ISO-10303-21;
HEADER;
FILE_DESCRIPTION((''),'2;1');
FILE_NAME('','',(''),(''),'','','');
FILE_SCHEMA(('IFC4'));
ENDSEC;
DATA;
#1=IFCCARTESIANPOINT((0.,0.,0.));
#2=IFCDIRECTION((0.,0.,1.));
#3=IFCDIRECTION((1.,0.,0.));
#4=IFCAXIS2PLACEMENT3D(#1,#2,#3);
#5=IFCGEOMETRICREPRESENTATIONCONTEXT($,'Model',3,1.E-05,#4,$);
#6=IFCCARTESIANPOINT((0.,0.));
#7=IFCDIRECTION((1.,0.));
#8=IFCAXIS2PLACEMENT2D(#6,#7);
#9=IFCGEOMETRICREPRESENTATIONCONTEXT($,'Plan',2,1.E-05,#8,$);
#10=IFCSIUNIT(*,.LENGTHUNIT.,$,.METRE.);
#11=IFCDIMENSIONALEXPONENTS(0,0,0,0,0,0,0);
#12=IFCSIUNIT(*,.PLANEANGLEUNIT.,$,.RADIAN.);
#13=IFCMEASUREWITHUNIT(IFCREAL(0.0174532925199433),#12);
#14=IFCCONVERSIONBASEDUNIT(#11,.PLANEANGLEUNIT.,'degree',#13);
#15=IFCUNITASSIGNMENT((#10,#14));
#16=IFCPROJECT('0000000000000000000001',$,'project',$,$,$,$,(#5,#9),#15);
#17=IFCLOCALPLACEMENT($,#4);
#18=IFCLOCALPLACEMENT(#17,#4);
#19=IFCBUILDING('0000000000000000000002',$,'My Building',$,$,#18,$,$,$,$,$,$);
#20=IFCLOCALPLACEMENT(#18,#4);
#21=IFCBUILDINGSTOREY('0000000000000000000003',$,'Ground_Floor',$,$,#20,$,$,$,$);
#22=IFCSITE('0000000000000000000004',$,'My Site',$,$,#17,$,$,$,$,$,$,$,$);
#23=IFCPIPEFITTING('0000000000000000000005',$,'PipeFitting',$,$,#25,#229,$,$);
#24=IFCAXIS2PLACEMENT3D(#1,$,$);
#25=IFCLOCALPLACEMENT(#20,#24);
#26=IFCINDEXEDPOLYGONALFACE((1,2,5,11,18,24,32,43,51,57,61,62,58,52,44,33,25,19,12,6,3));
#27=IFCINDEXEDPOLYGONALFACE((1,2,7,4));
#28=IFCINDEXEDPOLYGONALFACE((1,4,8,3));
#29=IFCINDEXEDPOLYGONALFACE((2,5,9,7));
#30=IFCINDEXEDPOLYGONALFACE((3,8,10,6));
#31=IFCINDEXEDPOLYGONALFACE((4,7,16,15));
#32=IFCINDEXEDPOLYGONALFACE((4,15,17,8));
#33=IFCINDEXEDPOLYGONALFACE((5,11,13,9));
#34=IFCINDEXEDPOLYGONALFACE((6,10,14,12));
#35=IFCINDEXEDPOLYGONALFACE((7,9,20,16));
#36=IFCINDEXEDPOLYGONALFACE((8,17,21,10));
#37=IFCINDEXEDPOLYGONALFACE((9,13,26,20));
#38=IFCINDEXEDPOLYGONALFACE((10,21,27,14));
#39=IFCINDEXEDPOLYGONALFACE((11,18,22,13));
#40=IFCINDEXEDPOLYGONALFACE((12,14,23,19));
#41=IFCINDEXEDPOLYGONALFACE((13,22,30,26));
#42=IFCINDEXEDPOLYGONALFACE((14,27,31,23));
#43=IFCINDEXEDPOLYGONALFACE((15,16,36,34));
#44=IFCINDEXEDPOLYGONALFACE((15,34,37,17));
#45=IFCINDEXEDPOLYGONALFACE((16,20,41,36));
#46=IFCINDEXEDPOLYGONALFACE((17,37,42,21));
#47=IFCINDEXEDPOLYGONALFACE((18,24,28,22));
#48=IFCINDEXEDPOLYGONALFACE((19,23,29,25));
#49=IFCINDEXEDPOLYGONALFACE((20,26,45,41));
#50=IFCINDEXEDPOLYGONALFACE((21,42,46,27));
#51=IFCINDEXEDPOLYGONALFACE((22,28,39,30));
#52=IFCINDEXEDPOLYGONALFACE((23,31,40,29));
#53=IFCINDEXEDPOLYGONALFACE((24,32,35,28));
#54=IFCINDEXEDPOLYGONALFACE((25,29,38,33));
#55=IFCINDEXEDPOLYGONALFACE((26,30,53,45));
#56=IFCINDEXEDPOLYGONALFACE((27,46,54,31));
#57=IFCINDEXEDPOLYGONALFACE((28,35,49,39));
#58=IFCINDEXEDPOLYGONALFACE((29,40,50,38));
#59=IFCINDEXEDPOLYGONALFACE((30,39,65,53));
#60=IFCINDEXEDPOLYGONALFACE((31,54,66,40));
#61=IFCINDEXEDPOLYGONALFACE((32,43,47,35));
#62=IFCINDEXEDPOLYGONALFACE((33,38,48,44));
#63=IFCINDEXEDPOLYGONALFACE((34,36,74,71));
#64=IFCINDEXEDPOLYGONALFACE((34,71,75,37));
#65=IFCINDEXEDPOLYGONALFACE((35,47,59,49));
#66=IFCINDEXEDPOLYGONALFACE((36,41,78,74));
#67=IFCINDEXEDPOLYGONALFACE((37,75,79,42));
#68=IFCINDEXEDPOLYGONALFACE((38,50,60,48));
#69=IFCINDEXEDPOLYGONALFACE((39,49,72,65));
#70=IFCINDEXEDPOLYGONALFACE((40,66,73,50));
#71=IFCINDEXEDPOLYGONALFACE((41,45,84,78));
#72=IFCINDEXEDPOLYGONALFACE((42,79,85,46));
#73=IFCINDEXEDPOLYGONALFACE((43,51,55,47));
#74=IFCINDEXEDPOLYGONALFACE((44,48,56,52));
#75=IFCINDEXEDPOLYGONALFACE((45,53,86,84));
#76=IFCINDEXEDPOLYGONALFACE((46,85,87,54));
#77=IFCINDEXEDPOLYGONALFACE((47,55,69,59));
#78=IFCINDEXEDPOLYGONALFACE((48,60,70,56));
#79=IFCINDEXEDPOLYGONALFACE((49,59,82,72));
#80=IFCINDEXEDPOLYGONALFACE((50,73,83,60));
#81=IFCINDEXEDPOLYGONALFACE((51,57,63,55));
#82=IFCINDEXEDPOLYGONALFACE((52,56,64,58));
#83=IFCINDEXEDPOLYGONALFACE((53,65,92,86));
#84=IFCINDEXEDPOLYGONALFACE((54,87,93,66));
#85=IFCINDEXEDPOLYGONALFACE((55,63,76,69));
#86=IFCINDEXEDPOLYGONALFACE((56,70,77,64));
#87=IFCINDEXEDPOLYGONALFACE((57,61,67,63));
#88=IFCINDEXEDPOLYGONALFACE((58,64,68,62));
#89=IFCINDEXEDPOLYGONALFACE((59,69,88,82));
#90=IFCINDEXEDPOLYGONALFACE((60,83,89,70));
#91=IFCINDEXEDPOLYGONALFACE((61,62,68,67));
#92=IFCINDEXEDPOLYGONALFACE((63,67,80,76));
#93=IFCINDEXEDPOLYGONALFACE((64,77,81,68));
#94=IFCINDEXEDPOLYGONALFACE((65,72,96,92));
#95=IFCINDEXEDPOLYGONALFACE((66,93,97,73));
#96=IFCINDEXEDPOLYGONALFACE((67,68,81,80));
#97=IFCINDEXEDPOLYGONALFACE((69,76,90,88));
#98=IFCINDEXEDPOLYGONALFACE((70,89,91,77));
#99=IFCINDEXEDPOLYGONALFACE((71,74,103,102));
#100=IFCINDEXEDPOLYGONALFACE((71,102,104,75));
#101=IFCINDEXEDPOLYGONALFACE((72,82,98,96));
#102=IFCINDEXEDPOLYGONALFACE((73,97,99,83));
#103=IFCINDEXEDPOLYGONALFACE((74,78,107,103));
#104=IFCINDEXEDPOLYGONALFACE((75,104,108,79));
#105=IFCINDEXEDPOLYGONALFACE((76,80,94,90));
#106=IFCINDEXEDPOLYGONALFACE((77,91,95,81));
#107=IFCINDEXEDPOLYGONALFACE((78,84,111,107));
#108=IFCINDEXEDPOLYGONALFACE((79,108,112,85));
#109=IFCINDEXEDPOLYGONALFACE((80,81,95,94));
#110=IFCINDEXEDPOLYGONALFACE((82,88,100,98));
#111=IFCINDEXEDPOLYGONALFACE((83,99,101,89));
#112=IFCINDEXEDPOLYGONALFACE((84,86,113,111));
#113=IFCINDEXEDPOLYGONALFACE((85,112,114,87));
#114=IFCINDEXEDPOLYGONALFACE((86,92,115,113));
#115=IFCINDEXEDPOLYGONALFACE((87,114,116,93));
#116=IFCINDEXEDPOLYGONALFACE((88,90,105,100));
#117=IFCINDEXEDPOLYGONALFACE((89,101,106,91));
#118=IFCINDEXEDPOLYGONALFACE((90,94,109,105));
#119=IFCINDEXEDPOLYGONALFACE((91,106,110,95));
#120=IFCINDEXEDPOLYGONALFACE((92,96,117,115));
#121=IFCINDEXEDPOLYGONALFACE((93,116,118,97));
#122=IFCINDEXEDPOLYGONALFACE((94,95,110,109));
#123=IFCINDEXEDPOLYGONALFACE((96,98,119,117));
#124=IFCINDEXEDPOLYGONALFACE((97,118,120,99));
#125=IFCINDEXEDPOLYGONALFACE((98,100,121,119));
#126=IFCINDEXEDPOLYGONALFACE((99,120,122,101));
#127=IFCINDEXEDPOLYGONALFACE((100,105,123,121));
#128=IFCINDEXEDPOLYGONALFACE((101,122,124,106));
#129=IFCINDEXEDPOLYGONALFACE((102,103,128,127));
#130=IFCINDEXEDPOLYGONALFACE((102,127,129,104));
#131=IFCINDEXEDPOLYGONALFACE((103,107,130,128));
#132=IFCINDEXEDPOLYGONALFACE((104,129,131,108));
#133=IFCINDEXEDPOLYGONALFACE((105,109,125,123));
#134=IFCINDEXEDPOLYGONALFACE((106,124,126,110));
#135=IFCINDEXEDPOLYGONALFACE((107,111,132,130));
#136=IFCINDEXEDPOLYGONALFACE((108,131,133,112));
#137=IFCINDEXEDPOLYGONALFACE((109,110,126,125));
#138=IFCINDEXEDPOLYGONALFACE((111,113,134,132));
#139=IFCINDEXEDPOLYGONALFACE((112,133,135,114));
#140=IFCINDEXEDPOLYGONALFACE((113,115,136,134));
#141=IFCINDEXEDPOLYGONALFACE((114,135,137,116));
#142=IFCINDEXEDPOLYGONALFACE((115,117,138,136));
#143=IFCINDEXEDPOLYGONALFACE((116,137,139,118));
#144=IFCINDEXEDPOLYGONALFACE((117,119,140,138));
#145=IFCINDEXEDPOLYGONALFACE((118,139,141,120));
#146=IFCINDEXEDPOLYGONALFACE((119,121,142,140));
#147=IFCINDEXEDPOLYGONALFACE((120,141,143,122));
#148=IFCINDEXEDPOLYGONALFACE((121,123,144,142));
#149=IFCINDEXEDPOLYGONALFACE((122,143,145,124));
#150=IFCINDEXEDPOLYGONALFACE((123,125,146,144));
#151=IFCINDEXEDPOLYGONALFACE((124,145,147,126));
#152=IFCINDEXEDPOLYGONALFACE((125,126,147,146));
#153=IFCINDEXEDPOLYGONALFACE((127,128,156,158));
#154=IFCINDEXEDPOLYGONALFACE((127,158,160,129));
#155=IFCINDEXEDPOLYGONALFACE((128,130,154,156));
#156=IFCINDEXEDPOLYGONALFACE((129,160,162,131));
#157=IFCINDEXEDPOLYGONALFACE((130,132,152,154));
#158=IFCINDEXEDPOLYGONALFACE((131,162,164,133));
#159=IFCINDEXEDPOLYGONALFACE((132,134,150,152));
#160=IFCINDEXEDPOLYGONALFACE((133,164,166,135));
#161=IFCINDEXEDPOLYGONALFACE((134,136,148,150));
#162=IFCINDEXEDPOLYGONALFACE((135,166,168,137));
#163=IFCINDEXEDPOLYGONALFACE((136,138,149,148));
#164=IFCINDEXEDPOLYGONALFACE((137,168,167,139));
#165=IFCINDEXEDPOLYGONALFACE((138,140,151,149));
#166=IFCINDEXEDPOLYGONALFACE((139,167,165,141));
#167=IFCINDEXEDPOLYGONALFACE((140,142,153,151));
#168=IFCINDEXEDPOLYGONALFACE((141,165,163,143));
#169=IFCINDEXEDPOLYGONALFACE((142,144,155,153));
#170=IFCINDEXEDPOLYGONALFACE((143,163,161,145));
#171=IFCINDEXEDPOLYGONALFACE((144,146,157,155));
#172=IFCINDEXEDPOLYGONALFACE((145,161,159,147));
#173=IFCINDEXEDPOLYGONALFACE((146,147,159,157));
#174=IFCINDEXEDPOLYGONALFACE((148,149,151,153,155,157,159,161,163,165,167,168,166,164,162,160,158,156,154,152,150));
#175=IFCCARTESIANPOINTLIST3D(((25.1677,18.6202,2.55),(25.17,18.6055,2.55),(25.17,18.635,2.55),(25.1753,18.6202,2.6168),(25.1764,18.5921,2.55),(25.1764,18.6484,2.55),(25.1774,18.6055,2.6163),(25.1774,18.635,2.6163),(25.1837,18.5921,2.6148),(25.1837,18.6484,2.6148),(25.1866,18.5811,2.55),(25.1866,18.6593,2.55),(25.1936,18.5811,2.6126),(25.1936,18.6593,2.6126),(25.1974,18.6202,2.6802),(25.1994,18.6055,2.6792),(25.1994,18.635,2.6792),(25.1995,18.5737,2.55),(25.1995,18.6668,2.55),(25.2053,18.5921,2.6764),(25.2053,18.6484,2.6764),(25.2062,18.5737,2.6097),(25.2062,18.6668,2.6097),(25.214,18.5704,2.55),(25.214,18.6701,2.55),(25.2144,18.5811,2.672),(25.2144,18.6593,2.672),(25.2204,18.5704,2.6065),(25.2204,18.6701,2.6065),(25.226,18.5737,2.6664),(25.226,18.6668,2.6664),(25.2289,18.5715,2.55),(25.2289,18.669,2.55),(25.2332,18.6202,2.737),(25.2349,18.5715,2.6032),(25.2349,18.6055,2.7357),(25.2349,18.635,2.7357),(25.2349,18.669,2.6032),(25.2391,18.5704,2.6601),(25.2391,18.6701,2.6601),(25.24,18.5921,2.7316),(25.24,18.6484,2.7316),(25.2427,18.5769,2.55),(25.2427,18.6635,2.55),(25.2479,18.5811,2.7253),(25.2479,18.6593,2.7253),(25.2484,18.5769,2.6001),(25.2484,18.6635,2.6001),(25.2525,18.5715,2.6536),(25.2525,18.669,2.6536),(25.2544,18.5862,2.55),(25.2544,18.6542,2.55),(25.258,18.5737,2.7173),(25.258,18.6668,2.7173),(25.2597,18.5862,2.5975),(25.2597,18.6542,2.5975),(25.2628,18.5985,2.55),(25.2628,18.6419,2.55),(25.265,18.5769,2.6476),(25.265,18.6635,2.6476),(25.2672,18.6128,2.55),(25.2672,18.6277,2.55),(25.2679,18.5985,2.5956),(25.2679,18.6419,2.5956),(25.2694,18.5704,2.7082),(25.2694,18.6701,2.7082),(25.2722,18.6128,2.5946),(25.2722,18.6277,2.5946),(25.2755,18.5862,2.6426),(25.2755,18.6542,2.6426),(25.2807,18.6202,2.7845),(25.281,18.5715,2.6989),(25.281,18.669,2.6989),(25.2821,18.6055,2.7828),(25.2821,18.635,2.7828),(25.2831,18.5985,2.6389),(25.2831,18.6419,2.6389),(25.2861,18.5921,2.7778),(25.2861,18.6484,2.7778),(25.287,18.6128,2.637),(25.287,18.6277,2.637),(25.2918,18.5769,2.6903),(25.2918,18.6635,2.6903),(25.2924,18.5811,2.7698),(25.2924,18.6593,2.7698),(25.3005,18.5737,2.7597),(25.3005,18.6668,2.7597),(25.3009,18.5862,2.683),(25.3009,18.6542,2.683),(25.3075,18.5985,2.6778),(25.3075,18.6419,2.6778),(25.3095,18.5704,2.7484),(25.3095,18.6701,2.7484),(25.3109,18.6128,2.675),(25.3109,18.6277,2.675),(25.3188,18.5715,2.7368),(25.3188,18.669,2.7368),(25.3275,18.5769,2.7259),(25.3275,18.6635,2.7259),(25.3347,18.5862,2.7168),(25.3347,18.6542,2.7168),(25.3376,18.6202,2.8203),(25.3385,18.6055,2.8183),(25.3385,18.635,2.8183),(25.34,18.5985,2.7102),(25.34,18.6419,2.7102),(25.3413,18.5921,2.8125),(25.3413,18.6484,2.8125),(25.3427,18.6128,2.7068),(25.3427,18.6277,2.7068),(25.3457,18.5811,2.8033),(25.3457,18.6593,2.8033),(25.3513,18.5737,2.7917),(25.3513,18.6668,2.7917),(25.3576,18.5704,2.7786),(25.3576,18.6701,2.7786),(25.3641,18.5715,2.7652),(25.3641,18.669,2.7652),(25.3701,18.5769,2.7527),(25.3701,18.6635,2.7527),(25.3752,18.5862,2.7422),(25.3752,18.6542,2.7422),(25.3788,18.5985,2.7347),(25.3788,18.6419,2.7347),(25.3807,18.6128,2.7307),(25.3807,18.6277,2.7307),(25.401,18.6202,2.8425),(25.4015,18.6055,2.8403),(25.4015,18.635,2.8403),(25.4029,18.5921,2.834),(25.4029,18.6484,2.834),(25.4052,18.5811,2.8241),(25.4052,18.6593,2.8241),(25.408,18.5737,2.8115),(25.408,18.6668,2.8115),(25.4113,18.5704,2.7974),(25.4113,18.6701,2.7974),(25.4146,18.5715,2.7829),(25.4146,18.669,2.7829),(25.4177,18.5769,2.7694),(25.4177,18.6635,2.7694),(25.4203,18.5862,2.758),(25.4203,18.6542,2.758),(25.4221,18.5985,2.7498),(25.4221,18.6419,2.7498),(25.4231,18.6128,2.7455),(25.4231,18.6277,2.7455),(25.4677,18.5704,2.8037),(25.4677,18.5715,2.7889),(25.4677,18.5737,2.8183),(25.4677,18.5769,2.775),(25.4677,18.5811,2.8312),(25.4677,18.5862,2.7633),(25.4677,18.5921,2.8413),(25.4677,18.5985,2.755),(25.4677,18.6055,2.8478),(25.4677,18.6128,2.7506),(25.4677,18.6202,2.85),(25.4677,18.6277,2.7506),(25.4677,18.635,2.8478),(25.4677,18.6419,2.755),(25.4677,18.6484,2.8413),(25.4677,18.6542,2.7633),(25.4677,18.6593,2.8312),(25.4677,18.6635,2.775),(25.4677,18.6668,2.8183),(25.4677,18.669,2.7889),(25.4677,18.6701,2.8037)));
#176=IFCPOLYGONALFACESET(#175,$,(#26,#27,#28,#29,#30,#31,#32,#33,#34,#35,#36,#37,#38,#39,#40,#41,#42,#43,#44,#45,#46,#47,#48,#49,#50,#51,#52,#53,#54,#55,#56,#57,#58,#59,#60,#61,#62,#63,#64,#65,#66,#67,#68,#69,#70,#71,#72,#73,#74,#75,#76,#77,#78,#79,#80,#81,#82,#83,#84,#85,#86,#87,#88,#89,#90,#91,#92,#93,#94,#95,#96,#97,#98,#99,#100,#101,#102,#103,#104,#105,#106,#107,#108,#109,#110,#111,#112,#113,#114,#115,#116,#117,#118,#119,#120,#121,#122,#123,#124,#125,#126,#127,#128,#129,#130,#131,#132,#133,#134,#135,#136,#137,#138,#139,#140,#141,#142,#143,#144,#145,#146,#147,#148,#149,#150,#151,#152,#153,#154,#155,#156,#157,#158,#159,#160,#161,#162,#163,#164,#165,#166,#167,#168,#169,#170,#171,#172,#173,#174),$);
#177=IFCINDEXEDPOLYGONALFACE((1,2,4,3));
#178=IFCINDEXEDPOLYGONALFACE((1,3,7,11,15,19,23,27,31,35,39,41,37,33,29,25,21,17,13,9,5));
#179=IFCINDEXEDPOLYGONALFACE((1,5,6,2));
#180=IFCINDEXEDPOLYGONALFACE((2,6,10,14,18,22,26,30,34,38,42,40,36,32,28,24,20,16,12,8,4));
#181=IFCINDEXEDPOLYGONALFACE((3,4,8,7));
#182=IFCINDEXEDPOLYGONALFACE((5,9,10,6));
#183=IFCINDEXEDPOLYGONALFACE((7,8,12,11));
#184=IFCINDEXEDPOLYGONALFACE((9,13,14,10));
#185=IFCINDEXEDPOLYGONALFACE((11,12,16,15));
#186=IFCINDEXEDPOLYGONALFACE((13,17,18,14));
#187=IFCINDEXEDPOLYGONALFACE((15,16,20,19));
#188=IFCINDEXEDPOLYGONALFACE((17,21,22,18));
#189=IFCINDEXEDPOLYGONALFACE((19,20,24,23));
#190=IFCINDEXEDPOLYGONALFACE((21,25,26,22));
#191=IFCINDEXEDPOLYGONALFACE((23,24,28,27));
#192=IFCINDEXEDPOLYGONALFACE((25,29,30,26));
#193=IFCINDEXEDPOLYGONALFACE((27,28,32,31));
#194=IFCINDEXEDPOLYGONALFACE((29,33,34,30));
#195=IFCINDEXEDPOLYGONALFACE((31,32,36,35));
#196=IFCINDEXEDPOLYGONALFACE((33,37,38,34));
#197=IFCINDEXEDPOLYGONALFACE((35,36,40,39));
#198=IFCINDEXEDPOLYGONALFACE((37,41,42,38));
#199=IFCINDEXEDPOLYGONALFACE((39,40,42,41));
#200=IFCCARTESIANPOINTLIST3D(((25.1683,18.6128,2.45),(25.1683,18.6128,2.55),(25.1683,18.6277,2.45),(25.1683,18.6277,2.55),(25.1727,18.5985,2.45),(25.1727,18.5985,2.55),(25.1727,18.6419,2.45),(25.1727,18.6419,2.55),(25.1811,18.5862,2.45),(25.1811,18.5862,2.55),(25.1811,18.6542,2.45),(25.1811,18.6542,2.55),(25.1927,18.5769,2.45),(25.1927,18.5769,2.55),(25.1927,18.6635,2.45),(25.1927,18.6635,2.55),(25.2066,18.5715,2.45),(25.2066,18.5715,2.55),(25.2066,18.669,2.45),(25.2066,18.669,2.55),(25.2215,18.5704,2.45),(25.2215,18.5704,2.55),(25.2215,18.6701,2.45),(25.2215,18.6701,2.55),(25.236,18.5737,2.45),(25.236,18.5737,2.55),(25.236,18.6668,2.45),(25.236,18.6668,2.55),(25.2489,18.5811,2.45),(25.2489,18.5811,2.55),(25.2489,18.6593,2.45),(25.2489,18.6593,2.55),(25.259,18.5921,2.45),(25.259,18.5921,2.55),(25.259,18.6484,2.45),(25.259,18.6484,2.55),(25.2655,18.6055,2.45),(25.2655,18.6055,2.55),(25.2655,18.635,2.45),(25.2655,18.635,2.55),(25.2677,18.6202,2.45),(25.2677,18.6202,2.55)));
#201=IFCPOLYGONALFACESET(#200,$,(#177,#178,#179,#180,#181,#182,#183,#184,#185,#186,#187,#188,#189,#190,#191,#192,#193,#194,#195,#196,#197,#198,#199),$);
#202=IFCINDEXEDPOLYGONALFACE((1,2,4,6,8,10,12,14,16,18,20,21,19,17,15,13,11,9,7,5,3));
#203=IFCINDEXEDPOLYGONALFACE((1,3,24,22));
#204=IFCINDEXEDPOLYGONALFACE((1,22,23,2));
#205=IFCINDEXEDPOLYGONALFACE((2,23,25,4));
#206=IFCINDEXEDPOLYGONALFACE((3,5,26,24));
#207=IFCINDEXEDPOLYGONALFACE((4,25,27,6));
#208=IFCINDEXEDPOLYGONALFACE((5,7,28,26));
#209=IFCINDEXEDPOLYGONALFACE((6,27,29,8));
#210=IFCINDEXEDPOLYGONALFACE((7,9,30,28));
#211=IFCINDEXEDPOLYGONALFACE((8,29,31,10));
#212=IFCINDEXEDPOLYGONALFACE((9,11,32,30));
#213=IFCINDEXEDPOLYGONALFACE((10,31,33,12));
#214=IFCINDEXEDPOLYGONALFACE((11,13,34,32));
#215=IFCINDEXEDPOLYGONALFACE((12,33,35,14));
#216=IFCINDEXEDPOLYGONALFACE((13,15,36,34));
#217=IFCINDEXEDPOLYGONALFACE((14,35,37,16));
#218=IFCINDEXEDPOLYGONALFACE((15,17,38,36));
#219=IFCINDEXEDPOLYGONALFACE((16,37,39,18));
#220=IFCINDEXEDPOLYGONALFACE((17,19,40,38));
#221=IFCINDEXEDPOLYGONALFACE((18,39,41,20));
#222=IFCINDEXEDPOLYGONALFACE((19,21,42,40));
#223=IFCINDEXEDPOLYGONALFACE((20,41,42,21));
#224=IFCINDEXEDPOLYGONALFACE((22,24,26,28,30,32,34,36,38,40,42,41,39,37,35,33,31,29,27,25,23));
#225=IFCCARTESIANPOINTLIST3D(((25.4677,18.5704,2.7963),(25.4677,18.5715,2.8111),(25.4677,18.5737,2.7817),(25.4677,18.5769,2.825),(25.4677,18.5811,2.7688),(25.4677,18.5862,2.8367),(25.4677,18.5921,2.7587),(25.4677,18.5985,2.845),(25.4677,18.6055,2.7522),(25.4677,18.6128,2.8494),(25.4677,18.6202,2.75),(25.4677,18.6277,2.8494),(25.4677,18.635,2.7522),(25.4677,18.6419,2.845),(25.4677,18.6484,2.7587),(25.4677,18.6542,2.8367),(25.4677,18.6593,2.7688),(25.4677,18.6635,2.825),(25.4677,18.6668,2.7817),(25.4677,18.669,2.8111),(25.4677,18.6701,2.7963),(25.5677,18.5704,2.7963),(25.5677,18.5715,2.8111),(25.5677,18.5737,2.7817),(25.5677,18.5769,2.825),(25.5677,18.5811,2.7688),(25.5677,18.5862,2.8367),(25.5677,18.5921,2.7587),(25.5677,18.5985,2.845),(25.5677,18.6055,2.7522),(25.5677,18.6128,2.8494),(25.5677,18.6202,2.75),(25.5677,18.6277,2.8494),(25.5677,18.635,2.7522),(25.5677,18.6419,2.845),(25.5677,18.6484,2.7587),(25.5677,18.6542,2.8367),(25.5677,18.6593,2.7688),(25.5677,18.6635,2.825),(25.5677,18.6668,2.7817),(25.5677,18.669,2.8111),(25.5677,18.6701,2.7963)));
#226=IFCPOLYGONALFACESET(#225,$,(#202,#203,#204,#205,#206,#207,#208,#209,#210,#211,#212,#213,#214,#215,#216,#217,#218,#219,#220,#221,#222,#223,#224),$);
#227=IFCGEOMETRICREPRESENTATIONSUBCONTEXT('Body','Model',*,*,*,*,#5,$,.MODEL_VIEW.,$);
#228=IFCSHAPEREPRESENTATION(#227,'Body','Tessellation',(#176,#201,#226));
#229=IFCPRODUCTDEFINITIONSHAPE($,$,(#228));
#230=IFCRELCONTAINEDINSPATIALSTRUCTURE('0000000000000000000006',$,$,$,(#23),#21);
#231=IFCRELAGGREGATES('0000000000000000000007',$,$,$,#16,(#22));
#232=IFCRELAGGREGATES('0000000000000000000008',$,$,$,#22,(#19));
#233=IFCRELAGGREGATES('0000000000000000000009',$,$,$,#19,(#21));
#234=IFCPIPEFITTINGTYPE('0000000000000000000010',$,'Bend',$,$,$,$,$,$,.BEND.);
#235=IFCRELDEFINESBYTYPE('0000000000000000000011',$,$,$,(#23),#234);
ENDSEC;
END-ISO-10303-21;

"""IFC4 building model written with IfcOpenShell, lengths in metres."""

from ifc_helpers import new_model, entity, si_unit, converted_unit, frame, origin_with_axes, origin_2d_with_axis, place, context, subcontext, project, spatial, circle, extrude, source, transform, mapped, type_object, type_shapes, element, save


model = new_model("IFC4")

# Units and contexts
model_context = context("Model", 3, precision=1e-05, world=origin_with_axes())
plan_context = context("Plan", 2, precision=1e-05, world=origin_2d_with_axis())
body_context = subcontext(model_context, "Body", "Model", "MODEL_VIEW")
ifc_project = project(units=[si_unit("LENGTHUNIT", "METRE"), converted_unit("PLANEANGLEUNIT", "degree", entity("IfcReal", 0.0174532925199433), si_unit("PLANEANGLEUNIT", "RADIAN"), dimensions=[0, 0, 0, 0, 0, 0, 0])], contexts=[model_context, plan_context])

# Site, building, storey
site_placement = place(None, origin_with_axes())
site = spatial("IfcSite", under=ifc_project, at=site_placement, Name="My Site")
building_placement = place(site_placement, origin_with_axes())
building = spatial("IfcBuilding", under=site, at=building_placement, Name="My Building")
storey_placement = place(building_placement, origin_with_axes())
storey = spatial("IfcBuildingStorey", under=building, at=storey_placement, Name="Ground_Floor")

# Pipe fitting
pipe_fitting_type = type_object("IfcPipeFittingType", Name="Bend", PredefinedType="BEND")
shared_shape = source(origin_with_axes(), body_context, "Body", "SolidModel", [
    entity("IfcSweptDiskSolid", entity("IfcIndexedPolyCurve", entity("IfcCartesianPointList3D", [[0.0, 0.0, -0.1], [0.0732, 0.0, -0.2768], [0.25, 0.0, -0.35]]), [entity("IfcArcIndex", [1, 2, 3])]), 0.05),
    extrude(circle(Radius=0.05), origin_with_axes(), (0.0, 0.0, -1.0), 0.1),
    extrude(circle(Radius=0.05), frame((0.25, 0.0, -0.35), z_axis=(1.0, 0.0, 0.0), x_axis=(0.0, 0.0, 1.0)), (0.0, 0.0, 1.0), 0.1),
])
type_shapes(pipe_fitting_type, [shared_shape])
for number, where, z_axis, x_axis, name in (
    (1, (25.2177, 18.6202, 2.45), (0.0, 0.0, -1.0), (1.0, 0.0, 0.0), "PipeFitting"),
):
    element("IfcPipeFitting", number, at=place(storey_placement, frame(where, z_axis=z_axis, x_axis=x_axis)), inside=storey, type_object=pipe_fitting_type, Name=name, context=body_context, shape_type="MappedRepresentation", body=[
        mapped(shared_shape, transform((0.0, 0.0, 0.0), x_axis=(1.0, 0.0, 0.0), y_axis=(0.0, 1.0, 0.0), z_axis=(0.0, 0.0, 1.0), scale=1.0)),
    ])

save(model, "model.ifc")
